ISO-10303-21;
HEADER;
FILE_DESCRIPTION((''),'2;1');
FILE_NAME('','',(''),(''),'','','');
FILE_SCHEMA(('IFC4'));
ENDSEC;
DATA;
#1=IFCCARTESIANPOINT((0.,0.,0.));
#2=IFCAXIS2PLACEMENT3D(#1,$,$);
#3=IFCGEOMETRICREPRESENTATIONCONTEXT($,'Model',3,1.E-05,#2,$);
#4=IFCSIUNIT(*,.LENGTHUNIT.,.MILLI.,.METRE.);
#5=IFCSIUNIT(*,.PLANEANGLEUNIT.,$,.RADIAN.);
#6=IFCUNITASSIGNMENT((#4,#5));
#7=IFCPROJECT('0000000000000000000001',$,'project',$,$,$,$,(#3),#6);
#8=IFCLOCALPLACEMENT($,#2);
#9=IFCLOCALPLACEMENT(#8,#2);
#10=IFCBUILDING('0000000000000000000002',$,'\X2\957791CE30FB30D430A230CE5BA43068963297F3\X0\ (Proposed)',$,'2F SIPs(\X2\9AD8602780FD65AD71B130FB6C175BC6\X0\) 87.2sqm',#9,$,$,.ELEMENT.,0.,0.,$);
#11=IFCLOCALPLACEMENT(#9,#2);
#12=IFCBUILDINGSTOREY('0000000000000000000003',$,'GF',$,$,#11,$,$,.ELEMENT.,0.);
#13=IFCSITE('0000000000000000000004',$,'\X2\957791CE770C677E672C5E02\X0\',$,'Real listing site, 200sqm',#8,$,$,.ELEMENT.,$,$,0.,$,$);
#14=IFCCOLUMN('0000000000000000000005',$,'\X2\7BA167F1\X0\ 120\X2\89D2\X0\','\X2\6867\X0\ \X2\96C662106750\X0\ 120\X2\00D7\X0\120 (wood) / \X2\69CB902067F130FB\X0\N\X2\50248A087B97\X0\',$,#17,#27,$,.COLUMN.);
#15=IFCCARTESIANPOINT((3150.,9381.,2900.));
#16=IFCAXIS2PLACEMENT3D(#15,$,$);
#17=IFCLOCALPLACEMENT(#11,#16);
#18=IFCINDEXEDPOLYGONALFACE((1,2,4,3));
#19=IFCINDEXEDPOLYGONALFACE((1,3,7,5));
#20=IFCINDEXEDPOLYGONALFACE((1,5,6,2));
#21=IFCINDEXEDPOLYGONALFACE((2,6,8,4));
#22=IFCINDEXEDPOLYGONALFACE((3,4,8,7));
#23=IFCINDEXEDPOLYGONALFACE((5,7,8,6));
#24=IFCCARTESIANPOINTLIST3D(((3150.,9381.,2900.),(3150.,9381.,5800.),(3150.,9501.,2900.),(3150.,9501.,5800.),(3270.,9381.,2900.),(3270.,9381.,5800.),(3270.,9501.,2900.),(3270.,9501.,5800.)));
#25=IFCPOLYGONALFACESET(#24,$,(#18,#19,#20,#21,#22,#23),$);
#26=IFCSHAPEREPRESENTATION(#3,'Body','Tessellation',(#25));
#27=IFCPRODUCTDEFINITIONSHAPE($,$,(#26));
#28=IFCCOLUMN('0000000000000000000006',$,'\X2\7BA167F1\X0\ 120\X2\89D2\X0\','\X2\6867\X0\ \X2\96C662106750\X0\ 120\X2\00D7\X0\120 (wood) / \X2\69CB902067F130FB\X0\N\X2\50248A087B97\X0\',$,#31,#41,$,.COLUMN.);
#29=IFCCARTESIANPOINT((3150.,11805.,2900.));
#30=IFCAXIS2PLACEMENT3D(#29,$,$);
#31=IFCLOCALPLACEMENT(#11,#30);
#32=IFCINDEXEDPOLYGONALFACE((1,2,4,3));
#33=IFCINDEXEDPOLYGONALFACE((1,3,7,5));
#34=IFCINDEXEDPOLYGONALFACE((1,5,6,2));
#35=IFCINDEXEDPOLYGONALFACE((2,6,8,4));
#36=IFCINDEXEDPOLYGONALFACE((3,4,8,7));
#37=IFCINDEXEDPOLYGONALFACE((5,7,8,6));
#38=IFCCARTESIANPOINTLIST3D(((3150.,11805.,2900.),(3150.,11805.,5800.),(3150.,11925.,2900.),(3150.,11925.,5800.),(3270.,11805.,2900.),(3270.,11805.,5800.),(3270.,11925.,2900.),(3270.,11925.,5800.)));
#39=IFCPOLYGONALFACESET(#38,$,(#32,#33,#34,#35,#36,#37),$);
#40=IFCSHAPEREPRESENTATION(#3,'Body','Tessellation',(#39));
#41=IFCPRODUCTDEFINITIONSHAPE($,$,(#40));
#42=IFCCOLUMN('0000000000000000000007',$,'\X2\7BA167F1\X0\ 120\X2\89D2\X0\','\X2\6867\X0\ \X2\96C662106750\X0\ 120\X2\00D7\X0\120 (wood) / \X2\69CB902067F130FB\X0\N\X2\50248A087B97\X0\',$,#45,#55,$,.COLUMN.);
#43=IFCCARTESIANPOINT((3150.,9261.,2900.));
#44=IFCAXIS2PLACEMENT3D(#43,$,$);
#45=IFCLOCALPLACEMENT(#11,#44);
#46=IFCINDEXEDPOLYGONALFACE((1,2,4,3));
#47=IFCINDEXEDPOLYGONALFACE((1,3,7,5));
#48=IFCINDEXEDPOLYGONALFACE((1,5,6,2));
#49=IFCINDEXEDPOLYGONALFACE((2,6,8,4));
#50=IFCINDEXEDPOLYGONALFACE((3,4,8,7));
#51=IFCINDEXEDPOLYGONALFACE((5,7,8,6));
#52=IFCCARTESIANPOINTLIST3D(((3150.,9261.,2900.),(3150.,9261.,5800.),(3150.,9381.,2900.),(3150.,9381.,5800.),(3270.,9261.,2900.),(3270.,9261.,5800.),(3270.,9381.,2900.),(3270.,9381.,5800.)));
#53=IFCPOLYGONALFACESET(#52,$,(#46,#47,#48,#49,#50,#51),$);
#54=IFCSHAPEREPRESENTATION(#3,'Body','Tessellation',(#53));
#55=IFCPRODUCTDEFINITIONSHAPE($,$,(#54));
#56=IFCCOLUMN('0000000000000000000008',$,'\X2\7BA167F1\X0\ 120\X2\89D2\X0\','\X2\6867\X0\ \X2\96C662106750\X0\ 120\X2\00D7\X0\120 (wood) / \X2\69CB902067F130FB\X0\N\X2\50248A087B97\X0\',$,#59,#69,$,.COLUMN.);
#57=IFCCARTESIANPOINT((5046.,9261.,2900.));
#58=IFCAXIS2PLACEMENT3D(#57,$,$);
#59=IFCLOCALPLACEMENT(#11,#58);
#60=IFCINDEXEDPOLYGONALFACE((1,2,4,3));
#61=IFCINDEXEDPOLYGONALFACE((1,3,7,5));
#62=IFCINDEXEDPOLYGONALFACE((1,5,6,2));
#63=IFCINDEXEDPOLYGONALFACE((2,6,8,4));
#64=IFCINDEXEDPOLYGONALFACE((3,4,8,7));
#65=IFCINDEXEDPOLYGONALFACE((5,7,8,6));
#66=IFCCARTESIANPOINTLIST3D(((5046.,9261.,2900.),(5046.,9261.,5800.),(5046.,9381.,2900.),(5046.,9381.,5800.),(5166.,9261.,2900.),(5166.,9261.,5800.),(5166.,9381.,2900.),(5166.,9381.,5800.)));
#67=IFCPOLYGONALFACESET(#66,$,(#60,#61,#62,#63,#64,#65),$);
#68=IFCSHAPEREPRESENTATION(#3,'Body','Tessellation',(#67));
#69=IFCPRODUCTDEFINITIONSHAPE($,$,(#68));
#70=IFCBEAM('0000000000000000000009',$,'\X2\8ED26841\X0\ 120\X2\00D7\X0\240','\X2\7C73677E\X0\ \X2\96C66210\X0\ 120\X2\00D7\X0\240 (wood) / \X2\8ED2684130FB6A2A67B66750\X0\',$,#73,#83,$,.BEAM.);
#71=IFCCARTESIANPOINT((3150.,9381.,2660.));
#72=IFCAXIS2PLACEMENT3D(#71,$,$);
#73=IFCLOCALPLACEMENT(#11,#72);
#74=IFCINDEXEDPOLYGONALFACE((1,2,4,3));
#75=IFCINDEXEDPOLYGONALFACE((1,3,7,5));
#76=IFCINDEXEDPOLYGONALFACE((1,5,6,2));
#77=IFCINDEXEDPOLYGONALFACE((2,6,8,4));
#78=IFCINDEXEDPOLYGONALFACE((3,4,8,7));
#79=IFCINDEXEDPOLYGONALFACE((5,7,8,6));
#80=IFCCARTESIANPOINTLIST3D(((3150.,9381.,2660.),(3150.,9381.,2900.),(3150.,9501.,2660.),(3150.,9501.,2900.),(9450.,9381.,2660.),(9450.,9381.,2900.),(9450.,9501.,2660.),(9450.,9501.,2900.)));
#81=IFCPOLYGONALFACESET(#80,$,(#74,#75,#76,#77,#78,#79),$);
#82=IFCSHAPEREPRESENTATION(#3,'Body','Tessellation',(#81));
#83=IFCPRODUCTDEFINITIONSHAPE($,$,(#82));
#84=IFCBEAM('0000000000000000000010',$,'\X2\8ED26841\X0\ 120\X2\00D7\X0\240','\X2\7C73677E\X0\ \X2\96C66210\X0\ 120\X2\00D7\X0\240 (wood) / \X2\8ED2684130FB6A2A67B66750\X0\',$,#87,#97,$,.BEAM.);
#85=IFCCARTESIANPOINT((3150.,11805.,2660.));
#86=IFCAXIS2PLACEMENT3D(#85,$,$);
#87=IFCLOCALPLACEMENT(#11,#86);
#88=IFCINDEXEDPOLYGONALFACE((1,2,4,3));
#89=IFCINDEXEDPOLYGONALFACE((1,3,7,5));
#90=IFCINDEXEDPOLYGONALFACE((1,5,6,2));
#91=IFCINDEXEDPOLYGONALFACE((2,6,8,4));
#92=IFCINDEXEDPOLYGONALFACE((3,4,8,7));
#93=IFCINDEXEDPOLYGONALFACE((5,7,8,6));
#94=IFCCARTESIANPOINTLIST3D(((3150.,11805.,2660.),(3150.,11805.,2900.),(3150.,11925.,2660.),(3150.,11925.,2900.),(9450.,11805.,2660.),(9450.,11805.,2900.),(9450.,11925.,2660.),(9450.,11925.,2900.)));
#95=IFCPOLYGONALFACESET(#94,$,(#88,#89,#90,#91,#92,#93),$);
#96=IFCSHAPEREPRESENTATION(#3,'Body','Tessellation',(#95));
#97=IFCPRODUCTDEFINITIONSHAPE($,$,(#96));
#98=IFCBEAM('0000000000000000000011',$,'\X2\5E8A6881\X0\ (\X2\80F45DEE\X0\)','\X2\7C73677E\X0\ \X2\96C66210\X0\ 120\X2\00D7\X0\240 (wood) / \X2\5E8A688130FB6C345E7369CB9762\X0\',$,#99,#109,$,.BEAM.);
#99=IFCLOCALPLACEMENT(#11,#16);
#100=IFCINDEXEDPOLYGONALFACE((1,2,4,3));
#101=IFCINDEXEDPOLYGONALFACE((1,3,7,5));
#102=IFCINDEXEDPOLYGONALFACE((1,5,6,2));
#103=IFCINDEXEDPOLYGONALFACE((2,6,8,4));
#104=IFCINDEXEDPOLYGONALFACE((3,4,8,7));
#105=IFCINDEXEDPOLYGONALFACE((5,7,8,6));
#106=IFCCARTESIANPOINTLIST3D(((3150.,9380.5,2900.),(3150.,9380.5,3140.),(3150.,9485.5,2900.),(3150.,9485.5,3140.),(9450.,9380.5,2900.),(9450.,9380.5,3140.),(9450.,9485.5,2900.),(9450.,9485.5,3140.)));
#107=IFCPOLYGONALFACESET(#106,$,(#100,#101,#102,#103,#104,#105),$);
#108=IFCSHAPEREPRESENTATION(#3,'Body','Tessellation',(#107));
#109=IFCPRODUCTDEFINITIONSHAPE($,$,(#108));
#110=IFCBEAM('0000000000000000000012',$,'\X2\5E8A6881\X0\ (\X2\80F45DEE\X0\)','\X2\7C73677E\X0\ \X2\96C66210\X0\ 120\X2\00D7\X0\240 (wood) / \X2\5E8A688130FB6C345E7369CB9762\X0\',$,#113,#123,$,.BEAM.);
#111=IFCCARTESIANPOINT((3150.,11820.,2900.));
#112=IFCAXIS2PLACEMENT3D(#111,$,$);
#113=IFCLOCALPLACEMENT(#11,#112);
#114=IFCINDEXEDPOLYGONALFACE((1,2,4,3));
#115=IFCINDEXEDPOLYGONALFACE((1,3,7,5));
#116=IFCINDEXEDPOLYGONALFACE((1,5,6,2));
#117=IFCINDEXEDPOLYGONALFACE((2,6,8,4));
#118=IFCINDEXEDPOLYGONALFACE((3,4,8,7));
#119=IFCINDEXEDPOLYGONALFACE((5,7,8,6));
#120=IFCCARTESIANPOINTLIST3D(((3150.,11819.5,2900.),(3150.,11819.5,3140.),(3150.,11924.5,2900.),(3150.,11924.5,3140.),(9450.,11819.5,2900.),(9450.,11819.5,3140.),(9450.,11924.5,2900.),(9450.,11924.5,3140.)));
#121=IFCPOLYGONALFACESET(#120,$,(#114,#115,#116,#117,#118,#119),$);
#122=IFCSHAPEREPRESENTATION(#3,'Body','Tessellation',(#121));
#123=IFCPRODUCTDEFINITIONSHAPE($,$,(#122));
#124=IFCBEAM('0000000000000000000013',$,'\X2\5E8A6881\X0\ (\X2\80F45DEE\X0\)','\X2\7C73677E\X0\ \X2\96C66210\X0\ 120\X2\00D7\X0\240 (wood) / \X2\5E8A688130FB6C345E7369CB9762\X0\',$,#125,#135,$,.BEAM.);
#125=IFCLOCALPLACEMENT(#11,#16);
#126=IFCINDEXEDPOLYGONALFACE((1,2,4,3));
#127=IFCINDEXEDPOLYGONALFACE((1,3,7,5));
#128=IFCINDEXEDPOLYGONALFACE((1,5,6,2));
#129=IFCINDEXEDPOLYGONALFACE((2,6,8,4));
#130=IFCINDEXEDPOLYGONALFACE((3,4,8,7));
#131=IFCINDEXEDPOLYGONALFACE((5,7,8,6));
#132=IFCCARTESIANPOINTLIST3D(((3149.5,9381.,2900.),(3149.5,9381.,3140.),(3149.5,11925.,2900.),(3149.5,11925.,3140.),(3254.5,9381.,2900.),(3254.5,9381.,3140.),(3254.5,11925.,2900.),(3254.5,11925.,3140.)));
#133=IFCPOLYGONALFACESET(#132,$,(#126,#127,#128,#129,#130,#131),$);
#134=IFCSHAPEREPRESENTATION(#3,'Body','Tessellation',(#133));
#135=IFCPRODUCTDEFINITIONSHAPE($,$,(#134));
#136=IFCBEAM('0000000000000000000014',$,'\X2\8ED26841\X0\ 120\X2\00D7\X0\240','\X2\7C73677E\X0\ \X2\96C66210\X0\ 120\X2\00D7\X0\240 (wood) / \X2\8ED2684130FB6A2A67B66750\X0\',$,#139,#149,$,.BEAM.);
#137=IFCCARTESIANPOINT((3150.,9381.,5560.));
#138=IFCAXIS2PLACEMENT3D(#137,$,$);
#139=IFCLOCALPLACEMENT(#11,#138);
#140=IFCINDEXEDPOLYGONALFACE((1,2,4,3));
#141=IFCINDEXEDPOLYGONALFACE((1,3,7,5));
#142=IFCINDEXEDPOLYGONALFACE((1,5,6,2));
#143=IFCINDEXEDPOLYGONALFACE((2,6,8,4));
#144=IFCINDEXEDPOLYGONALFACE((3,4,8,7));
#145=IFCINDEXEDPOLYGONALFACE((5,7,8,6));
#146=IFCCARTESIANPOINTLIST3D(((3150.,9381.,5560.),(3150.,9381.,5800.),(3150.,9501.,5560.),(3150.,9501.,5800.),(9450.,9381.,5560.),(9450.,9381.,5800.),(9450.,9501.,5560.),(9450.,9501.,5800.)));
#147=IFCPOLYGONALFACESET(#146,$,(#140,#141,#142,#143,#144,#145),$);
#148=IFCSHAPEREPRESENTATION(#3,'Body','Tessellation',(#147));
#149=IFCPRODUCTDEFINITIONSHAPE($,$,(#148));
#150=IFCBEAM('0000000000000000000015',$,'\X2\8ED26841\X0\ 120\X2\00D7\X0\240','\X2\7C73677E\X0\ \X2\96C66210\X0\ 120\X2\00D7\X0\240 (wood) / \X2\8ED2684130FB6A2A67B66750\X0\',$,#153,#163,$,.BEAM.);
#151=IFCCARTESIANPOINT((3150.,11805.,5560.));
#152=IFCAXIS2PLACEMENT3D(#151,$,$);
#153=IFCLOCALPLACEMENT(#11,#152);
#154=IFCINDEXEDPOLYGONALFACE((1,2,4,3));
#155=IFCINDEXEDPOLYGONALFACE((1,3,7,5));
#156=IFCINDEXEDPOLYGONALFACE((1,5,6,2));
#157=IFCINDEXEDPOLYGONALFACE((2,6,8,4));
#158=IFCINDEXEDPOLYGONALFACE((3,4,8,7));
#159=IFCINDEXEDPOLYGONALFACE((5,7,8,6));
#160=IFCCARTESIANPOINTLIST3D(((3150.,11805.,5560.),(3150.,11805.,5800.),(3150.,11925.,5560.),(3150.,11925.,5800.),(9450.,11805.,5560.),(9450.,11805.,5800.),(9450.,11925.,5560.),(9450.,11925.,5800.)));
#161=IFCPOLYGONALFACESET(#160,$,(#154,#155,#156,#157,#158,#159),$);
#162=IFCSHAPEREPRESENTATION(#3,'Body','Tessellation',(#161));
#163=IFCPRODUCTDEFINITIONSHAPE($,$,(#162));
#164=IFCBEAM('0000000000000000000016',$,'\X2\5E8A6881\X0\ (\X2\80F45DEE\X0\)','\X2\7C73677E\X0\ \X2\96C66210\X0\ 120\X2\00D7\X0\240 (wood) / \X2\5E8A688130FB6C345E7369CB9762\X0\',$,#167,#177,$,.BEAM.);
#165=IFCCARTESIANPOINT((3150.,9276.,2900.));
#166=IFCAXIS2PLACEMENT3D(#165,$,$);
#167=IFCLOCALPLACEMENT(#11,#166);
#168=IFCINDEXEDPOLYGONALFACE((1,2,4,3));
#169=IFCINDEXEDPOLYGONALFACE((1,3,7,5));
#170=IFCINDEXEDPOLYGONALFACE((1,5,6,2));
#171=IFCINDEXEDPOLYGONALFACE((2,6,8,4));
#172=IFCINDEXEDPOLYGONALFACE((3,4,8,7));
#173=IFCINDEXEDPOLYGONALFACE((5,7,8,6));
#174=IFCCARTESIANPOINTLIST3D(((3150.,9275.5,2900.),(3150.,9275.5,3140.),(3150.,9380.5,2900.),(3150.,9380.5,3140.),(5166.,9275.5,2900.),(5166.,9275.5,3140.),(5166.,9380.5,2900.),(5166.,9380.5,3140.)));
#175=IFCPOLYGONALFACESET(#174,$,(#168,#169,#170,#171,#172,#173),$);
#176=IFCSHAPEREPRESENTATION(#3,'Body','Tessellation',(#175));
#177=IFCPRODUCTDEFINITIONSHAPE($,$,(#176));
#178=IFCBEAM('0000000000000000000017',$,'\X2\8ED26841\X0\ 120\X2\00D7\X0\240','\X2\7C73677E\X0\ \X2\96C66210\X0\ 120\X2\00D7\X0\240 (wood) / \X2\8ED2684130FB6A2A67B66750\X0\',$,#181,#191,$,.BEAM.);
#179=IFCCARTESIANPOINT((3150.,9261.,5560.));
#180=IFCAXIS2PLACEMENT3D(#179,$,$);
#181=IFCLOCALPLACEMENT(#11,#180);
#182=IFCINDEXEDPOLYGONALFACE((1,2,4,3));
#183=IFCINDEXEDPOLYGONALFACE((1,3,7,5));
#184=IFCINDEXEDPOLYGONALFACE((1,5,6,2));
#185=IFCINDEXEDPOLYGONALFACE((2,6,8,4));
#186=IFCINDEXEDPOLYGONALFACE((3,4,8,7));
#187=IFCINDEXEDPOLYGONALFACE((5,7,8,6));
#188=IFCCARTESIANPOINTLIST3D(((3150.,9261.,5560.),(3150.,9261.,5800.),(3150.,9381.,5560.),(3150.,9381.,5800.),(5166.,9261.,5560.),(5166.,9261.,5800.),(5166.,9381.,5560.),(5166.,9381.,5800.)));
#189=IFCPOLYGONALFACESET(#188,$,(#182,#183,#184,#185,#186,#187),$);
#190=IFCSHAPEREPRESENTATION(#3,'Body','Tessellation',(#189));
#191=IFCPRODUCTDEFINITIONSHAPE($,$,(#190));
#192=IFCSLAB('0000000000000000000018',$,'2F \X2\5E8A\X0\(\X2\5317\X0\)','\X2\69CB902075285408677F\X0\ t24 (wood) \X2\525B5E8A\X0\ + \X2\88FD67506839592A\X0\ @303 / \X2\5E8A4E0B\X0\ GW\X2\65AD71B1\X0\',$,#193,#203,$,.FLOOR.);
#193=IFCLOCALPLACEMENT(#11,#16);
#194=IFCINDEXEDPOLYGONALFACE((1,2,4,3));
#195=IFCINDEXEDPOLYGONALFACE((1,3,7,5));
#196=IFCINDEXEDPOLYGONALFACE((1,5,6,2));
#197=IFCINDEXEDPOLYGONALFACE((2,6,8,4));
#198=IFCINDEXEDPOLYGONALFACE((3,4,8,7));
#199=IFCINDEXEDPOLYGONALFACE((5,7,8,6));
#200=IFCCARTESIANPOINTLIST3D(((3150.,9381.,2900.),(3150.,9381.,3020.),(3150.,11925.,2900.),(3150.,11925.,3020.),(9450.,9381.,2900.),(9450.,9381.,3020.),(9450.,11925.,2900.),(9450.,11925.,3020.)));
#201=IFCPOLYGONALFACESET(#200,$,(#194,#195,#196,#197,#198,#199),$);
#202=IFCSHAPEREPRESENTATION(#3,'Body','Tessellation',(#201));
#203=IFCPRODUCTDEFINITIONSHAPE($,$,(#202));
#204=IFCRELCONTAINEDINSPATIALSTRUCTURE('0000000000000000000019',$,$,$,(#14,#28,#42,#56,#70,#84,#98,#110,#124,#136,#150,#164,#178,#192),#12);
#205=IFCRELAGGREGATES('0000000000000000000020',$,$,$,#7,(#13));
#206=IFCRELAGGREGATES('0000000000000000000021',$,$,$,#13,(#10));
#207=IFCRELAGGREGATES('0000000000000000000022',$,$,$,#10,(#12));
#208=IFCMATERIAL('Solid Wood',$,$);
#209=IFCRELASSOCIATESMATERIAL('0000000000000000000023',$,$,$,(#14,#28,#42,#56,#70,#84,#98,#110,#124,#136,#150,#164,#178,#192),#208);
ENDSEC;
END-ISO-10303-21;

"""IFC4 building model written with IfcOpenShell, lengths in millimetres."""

from ifc_helpers import new_model, si_unit, frame, frame_2d, origin, place, context, project, spatial, rectangle, extrude, material, element, save


model = new_model("IFC4")

# Units and contexts
model_context = context("Model", 3, precision=1e-05, world=origin())
ifc_project = project(units=[si_unit("LENGTHUNIT", "METRE", prefix="MILLI"), si_unit("PLANEANGLEUNIT", "RADIAN")], contexts=[model_context])

# Site, building, storey
site_placement = place(None, origin())
site = spatial("IfcSite", under=ifc_project, at=site_placement, Name="長野県松本市", ObjectType="Real listing site, 200sqm", CompositionType="ELEMENT", RefElevation=0.0)
building_placement = place(site_placement, origin())
building = spatial("IfcBuilding", under=site, at=building_placement, Name="長野・ピアノ室と防音 (Proposed)", ObjectType="2F SIPs(高性能断熱・気密) 87.2sqm", CompositionType="ELEMENT", ElevationOfRefHeight=0.0, ElevationOfTerrain=0.0)
storey_placement = place(building_placement, origin())
storey = spatial("IfcBuildingStorey", under=building, at=storey_placement, Name="GF", CompositionType="ELEMENT", Elevation=0.0)

# Columns
ifc_material_1 = material(Name="Solid Wood")
column_1_placement = place(storey_placement, frame((3150.0, 9381.0, 2900.0)))
element("IfcColumn", 1, at=column_1_placement, inside=storey, material=ifc_material_1, Name="管柱 120角", Description="桧 集成材 120×120 (wood) / 構造柱・N値計算", PredefinedType="COLUMN", context=model_context, shape_type="SweptSolid", body=[
    extrude(rectangle(XDim=120.0, YDim=120.0, at=frame_2d((60.0, 60.0))), frame((3150.0, 9381.0, 2900.0)), (0.0, 0.0, 1.0), 2900.0),
])
column_2_placement = place(storey_placement, frame((3150.0, 11805.0, 2900.0)))
element("IfcColumn", 2, at=column_2_placement, inside=storey, material=ifc_material_1, Name="管柱 120角", Description="桧 集成材 120×120 (wood) / 構造柱・N値計算", PredefinedType="COLUMN", context=model_context, shape_type="SweptSolid", body=[
    extrude(rectangle(XDim=120.0, YDim=120.0, at=frame_2d((60.0, 60.0))), frame((3150.0, 11805.0, 2900.0)), (0.0, 0.0, 1.0), 2900.0),
])
column_3_placement = place(storey_placement, frame((3150.0, 9261.0, 2900.0)))
element("IfcColumn", 3, at=column_3_placement, inside=storey, material=ifc_material_1, Name="管柱 120角", Description="桧 集成材 120×120 (wood) / 構造柱・N値計算", PredefinedType="COLUMN", context=model_context, shape_type="SweptSolid", body=[
    extrude(rectangle(XDim=120.0, YDim=120.0, at=frame_2d((60.0, 60.0))), frame((3150.0, 9261.0, 2900.0)), (0.0, 0.0, 1.0), 2900.0),
])
column_4_placement = place(storey_placement, frame((5046.0, 9261.0, 2900.0)))
element("IfcColumn", 4, at=column_4_placement, inside=storey, material=ifc_material_1, Name="管柱 120角", Description="桧 集成材 120×120 (wood) / 構造柱・N値計算", PredefinedType="COLUMN", context=model_context, shape_type="SweptSolid", body=[
    extrude(rectangle(XDim=120.0, YDim=120.0, at=frame_2d((60.0, 60.0))), frame((5046.0, 9261.0, 2900.0)), (0.0, 0.0, 1.0), 2900.0),
])

# Beams
beam_1_placement = place(storey_placement, frame((3150.0, 9381.0, 2660.0)))
element("IfcBeam", 5, at=beam_1_placement, inside=storey, material=ifc_material_1, Name="軒桁 120×240", Description="米松 集成 120×240 (wood) / 軒桁・横架材", PredefinedType="BEAM", context=model_context, shape_type="SweptSolid", body=[
    extrude(rectangle(XDim=6300.0, YDim=120.0, at=frame_2d((3150.0, 60.0))), frame((3150.0, 9381.0, 2660.0)), (0.0, 0.0, 1.0), 240.0),
])
beam_2_placement = place(storey_placement, frame((3150.0, 11805.0, 2660.0)))
element("IfcBeam", 6, at=beam_2_placement, inside=storey, material=ifc_material_1, Name="軒桁 120×240", Description="米松 集成 120×240 (wood) / 軒桁・横架材", PredefinedType="BEAM", context=model_context, shape_type="SweptSolid", body=[
    extrude(rectangle(XDim=6300.0, YDim=120.0, at=frame_2d((3150.0, 60.0))), frame((3150.0, 11805.0, 2660.0)), (0.0, 0.0, 1.0), 240.0),
])
beam_3_placement = place(storey_placement, frame((3150.0, 9381.0, 2900.0)))
element("IfcBeam", 7, at=beam_3_placement, inside=storey, material=ifc_material_1, Name="床梁 (胴差)", Description="米松 集成 120×240 (wood) / 床梁・水平構面", PredefinedType="BEAM", context=model_context, shape_type="SweptSolid", body=[
    extrude(rectangle(XDim=6300.0, YDim=105.0, at=frame_2d((3150.0, 52.0))), frame((3150.0, 9381.0, 2900.0)), (0.0, 0.0, 1.0), 240.0),
])
beam_4_placement = place(storey_placement, frame((3150.0, 11820.0, 2900.0)))
element("IfcBeam", 8, at=beam_4_placement, inside=storey, material=ifc_material_1, Name="床梁 (胴差)", Description="米松 集成 120×240 (wood) / 床梁・水平構面", PredefinedType="BEAM", context=model_context, shape_type="SweptSolid", body=[
    extrude(rectangle(XDim=6300.0, YDim=105.0, at=frame_2d((3150.0, 52.0))), frame((3150.0, 11820.0, 2900.0)), (0.0, 0.0, 1.0), 240.0),
])
beam_5_placement = place(storey_placement, frame((3150.0, 9381.0, 2900.0)))
element("IfcBeam", 9, at=beam_5_placement, inside=storey, material=ifc_material_1, Name="床梁 (胴差)", Description="米松 集成 120×240 (wood) / 床梁・水平構面", PredefinedType="BEAM", context=model_context, shape_type="SweptSolid", body=[
    extrude(rectangle(XDim=105.0, YDim=2544.0, at=frame_2d((52.0, 1272.0))), frame((3150.0, 9381.0, 2900.0)), (0.0, 0.0, 1.0), 240.0),
])
beam_6_placement = place(storey_placement, frame((3150.0, 9381.0, 5560.0)))
element("IfcBeam", 10, at=beam_6_placement, inside=storey, material=ifc_material_1, Name="軒桁 120×240", Description="米松 集成 120×240 (wood) / 軒桁・横架材", PredefinedType="BEAM", context=model_context, shape_type="SweptSolid", body=[
    extrude(rectangle(XDim=6300.0, YDim=120.0, at=frame_2d((3150.0, 60.0))), frame((3150.0, 9381.0, 5560.0)), (0.0, 0.0, 1.0), 240.0),
])
beam_7_placement = place(storey_placement, frame((3150.0, 11805.0, 5560.0)))
element("IfcBeam", 11, at=beam_7_placement, inside=storey, material=ifc_material_1, Name="軒桁 120×240", Description="米松 集成 120×240 (wood) / 軒桁・横架材", PredefinedType="BEAM", context=model_context, shape_type="SweptSolid", body=[
    extrude(rectangle(XDim=6300.0, YDim=120.0, at=frame_2d((3150.0, 60.0))), frame((3150.0, 11805.0, 5560.0)), (0.0, 0.0, 1.0), 240.0),
])
beam_8_placement = place(storey_placement, frame((3150.0, 9276.0, 2900.0)))
element("IfcBeam", 12, at=beam_8_placement, inside=storey, material=ifc_material_1, Name="床梁 (胴差)", Description="米松 集成 120×240 (wood) / 床梁・水平構面", PredefinedType="BEAM", context=model_context, shape_type="SweptSolid", body=[
    extrude(rectangle(XDim=2016.0, YDim=105.0, at=frame_2d((1008.0, 52.0))), frame((3150.0, 9276.0, 2900.0)), (0.0, 0.0, 1.0), 240.0),
])
beam_9_placement = place(storey_placement, frame((3150.0, 9261.0, 5560.0)))
element("IfcBeam", 13, at=beam_9_placement, inside=storey, material=ifc_material_1, Name="軒桁 120×240", Description="米松 集成 120×240 (wood) / 軒桁・横架材", PredefinedType="BEAM", context=model_context, shape_type="SweptSolid", body=[
    extrude(rectangle(XDim=2016.0, YDim=120.0, at=frame_2d((1008.0, 60.0))), frame((3150.0, 9261.0, 5560.0)), (0.0, 0.0, 1.0), 240.0),
])

# Slab
slab_placement = place(storey_placement, frame((3150.0, 9381.0, 2900.0)))
element("IfcSlab", 14, at=slab_placement, inside=storey, material=ifc_material_1, Name="2F 床(北)", Description="構造用合板 t24 (wood) 剛床 + 製材根太 @303 / 床下 GW断熱", PredefinedType="FLOOR", context=model_context, shape_type="SweptSolid", body=[
    extrude(rectangle(XDim=6300.0, YDim=2544.0, at=frame_2d((3150.0, 1272.0))), frame((3150.0, 9381.0, 2900.0)), (0.0, 0.0, 1.0), 120.0),
])

save(model, "model.ifc")
